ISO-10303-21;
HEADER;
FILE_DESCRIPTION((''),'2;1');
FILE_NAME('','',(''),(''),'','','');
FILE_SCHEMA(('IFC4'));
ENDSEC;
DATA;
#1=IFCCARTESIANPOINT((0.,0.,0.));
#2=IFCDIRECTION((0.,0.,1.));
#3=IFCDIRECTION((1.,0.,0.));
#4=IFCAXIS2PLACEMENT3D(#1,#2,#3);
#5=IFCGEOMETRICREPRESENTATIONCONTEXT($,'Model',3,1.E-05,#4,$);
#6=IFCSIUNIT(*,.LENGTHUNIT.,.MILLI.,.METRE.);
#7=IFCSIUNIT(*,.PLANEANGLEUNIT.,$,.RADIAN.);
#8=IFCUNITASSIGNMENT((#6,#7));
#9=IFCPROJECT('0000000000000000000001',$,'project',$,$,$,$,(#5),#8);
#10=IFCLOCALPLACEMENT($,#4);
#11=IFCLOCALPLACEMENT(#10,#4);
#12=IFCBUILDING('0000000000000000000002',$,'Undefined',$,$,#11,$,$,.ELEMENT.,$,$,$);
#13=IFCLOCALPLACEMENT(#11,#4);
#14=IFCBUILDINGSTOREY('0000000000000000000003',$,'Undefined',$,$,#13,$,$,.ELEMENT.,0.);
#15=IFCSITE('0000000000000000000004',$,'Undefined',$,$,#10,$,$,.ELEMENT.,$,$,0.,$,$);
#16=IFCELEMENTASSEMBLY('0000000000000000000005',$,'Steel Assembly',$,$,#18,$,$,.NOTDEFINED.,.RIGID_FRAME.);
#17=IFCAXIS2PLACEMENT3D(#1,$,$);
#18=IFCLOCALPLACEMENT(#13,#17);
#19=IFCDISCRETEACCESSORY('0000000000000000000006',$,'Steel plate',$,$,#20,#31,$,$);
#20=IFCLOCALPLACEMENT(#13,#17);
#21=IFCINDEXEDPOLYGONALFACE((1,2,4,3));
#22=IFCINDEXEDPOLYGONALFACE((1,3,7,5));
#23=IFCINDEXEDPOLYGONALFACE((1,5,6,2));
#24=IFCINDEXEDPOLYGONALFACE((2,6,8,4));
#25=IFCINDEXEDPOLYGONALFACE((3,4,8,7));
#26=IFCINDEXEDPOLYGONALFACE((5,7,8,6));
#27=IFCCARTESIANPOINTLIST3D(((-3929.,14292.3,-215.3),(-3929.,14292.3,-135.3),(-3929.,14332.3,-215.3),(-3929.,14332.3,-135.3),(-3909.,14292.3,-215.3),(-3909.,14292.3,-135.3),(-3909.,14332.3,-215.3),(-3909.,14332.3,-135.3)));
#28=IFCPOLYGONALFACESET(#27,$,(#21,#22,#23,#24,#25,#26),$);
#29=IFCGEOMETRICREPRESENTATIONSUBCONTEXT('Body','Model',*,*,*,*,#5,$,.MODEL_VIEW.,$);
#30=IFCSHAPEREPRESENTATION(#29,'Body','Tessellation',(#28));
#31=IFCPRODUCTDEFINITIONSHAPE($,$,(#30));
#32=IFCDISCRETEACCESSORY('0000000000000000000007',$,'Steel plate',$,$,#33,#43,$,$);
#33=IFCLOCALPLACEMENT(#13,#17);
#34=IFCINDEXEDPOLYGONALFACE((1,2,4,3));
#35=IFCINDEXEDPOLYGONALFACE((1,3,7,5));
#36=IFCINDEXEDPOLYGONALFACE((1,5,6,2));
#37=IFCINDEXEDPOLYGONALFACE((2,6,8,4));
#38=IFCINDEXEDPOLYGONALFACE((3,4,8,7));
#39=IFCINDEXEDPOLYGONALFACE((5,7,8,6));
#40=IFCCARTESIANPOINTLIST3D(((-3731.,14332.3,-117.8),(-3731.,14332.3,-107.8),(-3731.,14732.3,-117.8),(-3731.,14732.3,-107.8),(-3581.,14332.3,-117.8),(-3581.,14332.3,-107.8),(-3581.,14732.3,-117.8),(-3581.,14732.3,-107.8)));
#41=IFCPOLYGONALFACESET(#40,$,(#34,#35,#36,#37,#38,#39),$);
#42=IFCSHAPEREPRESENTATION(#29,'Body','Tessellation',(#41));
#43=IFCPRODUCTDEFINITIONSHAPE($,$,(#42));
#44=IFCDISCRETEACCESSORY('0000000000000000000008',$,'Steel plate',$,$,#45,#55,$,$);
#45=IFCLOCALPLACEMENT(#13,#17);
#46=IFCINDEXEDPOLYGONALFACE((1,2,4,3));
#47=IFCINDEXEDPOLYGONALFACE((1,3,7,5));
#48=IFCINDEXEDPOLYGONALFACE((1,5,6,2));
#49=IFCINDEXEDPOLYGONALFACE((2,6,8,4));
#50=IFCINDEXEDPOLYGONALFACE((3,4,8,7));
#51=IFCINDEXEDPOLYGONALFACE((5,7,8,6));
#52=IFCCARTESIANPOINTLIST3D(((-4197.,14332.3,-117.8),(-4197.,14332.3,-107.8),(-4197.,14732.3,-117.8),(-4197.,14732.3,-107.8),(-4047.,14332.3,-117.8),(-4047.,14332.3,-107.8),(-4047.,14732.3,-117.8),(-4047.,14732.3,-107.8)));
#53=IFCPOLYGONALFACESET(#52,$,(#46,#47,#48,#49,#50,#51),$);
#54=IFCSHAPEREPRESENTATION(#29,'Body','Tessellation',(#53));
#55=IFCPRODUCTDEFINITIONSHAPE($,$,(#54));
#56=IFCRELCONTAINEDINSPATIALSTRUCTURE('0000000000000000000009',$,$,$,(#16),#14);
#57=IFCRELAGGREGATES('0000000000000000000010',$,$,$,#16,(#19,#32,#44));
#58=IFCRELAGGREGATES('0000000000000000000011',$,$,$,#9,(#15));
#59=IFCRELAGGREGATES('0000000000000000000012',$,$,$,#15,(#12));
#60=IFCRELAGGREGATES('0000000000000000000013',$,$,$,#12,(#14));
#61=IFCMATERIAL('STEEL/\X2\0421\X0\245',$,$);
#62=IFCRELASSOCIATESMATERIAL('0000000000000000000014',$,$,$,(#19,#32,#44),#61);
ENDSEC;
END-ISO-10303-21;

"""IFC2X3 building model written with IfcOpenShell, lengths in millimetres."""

from ifc_helpers import new_model, si_unit, frame, origin_with_axes, place, context, subcontext, project, spatial, polyline, outline, extrude, material, element, aggregate, save


model = new_model("IFC2X3")

# Units and contexts
model_context = context("Model", 3, precision=1e-05, world=origin_with_axes())
body_context = subcontext(model_context, "Body", "Model", "MODEL_VIEW")
ifc_project = project(units=[si_unit("LENGTHUNIT", "METRE", prefix="MILLI"), si_unit("PLANEANGLEUNIT", "RADIAN")], contexts=[model_context])

# Site, building, storey
site_placement = place(None, origin_with_axes())
site = spatial("IfcSite", under=ifc_project, at=site_placement, Name="Undefined", CompositionType="ELEMENT", RefElevation=0.0)
building_placement = place(site_placement, origin_with_axes())
building = spatial("IfcBuilding", under=site, at=building_placement, Name="Undefined", CompositionType="ELEMENT")
storey_placement = place(building_placement, origin_with_axes())
storey = spatial("IfcBuildingStorey", under=building, at=storey_placement, Name="Undefined", CompositionType="ELEMENT", Elevation=0.0)

# Shared definitions
ifc_material = material(Name="STEEL/С245")

# Element assembly
assembly_1_placement = place(storey_placement, origin_with_axes())
assembly_1 = element("IfcElementAssembly", 1, at=assembly_1_placement, inside=storey, Name="Steel Assembly", AssemblyPlace="NOTDEFINED", PredefinedType="RIGID_FRAME")

# Discrete accessories
discrete_accessory_1_placement = place(assembly_1_placement, frame((-3919.0, 14332.3, -215.3), z_axis=(1.0, 0.0, 0.0), x_axis=(0.0, 0.0, 1.0)))
discrete_accessory_1 = element("IfcDiscreteAccessory", 2, at=discrete_accessory_1_placement, material=ifc_material, Name="Steel plate", context=body_context, shape_type="SweptSolid", body=[
    extrude(outline(polyline([(0.0, 0.0), (80.0, 0.0), (80.0, 40.0), (0.0, 40.0), (0.0, 0.0)])), frame((0.0, 0.0, -10.0), z_axis=(0.0, 0.0, 1.0), x_axis=(1.0, 0.0, 0.0)), (0.0, 0.0, 1.0), 20.0),
])
discrete_accessory_2_placement = place(assembly_1_placement, frame((-3731.0, 14332.3, -112.8), z_axis=(0.0, 0.0, 1.0), x_axis=(1.0, 0.0, 0.0)))
discrete_accessory_2 = element("IfcDiscreteAccessory", 3, at=discrete_accessory_2_placement, material=ifc_material, Name="Steel plate", context=body_context, shape_type="SweptSolid", body=[
    extrude(outline(polyline([(0.0, 0.0), (150.0, 0.0), (150.0, 400.0), (0.0, 400.0), (0.0, 0.0)])), frame((0.0, 0.0, -5.0), z_axis=(0.0, 0.0, 1.0), x_axis=(1.0, 0.0, 0.0)), (0.0, 0.0, 1.0), 10.0),
])
discrete_accessory_3_placement = place(assembly_1_placement, frame((-4197.0, 14332.3, -112.8), z_axis=(0.0, 0.0, 1.0), x_axis=(1.0, 0.0, 0.0)))
discrete_accessory_3 = element("IfcDiscreteAccessory", 4, at=discrete_accessory_3_placement, material=ifc_material, Name="Steel plate", context=body_context, shape_type="SweptSolid", body=[
    extrude(outline(polyline([(0.0, 0.0), (150.0, 0.0), (150.0, 400.0), (0.0, 400.0), (0.0, 0.0)])), frame((0.0, 0.0, -5.0), z_axis=(0.0, 0.0, 1.0), x_axis=(1.0, 0.0, 0.0)), (0.0, 0.0, 1.0), 10.0),
])
aggregate(assembly_1, [discrete_accessory_1, discrete_accessory_2, discrete_accessory_3])

save(model, "model.ifc")
